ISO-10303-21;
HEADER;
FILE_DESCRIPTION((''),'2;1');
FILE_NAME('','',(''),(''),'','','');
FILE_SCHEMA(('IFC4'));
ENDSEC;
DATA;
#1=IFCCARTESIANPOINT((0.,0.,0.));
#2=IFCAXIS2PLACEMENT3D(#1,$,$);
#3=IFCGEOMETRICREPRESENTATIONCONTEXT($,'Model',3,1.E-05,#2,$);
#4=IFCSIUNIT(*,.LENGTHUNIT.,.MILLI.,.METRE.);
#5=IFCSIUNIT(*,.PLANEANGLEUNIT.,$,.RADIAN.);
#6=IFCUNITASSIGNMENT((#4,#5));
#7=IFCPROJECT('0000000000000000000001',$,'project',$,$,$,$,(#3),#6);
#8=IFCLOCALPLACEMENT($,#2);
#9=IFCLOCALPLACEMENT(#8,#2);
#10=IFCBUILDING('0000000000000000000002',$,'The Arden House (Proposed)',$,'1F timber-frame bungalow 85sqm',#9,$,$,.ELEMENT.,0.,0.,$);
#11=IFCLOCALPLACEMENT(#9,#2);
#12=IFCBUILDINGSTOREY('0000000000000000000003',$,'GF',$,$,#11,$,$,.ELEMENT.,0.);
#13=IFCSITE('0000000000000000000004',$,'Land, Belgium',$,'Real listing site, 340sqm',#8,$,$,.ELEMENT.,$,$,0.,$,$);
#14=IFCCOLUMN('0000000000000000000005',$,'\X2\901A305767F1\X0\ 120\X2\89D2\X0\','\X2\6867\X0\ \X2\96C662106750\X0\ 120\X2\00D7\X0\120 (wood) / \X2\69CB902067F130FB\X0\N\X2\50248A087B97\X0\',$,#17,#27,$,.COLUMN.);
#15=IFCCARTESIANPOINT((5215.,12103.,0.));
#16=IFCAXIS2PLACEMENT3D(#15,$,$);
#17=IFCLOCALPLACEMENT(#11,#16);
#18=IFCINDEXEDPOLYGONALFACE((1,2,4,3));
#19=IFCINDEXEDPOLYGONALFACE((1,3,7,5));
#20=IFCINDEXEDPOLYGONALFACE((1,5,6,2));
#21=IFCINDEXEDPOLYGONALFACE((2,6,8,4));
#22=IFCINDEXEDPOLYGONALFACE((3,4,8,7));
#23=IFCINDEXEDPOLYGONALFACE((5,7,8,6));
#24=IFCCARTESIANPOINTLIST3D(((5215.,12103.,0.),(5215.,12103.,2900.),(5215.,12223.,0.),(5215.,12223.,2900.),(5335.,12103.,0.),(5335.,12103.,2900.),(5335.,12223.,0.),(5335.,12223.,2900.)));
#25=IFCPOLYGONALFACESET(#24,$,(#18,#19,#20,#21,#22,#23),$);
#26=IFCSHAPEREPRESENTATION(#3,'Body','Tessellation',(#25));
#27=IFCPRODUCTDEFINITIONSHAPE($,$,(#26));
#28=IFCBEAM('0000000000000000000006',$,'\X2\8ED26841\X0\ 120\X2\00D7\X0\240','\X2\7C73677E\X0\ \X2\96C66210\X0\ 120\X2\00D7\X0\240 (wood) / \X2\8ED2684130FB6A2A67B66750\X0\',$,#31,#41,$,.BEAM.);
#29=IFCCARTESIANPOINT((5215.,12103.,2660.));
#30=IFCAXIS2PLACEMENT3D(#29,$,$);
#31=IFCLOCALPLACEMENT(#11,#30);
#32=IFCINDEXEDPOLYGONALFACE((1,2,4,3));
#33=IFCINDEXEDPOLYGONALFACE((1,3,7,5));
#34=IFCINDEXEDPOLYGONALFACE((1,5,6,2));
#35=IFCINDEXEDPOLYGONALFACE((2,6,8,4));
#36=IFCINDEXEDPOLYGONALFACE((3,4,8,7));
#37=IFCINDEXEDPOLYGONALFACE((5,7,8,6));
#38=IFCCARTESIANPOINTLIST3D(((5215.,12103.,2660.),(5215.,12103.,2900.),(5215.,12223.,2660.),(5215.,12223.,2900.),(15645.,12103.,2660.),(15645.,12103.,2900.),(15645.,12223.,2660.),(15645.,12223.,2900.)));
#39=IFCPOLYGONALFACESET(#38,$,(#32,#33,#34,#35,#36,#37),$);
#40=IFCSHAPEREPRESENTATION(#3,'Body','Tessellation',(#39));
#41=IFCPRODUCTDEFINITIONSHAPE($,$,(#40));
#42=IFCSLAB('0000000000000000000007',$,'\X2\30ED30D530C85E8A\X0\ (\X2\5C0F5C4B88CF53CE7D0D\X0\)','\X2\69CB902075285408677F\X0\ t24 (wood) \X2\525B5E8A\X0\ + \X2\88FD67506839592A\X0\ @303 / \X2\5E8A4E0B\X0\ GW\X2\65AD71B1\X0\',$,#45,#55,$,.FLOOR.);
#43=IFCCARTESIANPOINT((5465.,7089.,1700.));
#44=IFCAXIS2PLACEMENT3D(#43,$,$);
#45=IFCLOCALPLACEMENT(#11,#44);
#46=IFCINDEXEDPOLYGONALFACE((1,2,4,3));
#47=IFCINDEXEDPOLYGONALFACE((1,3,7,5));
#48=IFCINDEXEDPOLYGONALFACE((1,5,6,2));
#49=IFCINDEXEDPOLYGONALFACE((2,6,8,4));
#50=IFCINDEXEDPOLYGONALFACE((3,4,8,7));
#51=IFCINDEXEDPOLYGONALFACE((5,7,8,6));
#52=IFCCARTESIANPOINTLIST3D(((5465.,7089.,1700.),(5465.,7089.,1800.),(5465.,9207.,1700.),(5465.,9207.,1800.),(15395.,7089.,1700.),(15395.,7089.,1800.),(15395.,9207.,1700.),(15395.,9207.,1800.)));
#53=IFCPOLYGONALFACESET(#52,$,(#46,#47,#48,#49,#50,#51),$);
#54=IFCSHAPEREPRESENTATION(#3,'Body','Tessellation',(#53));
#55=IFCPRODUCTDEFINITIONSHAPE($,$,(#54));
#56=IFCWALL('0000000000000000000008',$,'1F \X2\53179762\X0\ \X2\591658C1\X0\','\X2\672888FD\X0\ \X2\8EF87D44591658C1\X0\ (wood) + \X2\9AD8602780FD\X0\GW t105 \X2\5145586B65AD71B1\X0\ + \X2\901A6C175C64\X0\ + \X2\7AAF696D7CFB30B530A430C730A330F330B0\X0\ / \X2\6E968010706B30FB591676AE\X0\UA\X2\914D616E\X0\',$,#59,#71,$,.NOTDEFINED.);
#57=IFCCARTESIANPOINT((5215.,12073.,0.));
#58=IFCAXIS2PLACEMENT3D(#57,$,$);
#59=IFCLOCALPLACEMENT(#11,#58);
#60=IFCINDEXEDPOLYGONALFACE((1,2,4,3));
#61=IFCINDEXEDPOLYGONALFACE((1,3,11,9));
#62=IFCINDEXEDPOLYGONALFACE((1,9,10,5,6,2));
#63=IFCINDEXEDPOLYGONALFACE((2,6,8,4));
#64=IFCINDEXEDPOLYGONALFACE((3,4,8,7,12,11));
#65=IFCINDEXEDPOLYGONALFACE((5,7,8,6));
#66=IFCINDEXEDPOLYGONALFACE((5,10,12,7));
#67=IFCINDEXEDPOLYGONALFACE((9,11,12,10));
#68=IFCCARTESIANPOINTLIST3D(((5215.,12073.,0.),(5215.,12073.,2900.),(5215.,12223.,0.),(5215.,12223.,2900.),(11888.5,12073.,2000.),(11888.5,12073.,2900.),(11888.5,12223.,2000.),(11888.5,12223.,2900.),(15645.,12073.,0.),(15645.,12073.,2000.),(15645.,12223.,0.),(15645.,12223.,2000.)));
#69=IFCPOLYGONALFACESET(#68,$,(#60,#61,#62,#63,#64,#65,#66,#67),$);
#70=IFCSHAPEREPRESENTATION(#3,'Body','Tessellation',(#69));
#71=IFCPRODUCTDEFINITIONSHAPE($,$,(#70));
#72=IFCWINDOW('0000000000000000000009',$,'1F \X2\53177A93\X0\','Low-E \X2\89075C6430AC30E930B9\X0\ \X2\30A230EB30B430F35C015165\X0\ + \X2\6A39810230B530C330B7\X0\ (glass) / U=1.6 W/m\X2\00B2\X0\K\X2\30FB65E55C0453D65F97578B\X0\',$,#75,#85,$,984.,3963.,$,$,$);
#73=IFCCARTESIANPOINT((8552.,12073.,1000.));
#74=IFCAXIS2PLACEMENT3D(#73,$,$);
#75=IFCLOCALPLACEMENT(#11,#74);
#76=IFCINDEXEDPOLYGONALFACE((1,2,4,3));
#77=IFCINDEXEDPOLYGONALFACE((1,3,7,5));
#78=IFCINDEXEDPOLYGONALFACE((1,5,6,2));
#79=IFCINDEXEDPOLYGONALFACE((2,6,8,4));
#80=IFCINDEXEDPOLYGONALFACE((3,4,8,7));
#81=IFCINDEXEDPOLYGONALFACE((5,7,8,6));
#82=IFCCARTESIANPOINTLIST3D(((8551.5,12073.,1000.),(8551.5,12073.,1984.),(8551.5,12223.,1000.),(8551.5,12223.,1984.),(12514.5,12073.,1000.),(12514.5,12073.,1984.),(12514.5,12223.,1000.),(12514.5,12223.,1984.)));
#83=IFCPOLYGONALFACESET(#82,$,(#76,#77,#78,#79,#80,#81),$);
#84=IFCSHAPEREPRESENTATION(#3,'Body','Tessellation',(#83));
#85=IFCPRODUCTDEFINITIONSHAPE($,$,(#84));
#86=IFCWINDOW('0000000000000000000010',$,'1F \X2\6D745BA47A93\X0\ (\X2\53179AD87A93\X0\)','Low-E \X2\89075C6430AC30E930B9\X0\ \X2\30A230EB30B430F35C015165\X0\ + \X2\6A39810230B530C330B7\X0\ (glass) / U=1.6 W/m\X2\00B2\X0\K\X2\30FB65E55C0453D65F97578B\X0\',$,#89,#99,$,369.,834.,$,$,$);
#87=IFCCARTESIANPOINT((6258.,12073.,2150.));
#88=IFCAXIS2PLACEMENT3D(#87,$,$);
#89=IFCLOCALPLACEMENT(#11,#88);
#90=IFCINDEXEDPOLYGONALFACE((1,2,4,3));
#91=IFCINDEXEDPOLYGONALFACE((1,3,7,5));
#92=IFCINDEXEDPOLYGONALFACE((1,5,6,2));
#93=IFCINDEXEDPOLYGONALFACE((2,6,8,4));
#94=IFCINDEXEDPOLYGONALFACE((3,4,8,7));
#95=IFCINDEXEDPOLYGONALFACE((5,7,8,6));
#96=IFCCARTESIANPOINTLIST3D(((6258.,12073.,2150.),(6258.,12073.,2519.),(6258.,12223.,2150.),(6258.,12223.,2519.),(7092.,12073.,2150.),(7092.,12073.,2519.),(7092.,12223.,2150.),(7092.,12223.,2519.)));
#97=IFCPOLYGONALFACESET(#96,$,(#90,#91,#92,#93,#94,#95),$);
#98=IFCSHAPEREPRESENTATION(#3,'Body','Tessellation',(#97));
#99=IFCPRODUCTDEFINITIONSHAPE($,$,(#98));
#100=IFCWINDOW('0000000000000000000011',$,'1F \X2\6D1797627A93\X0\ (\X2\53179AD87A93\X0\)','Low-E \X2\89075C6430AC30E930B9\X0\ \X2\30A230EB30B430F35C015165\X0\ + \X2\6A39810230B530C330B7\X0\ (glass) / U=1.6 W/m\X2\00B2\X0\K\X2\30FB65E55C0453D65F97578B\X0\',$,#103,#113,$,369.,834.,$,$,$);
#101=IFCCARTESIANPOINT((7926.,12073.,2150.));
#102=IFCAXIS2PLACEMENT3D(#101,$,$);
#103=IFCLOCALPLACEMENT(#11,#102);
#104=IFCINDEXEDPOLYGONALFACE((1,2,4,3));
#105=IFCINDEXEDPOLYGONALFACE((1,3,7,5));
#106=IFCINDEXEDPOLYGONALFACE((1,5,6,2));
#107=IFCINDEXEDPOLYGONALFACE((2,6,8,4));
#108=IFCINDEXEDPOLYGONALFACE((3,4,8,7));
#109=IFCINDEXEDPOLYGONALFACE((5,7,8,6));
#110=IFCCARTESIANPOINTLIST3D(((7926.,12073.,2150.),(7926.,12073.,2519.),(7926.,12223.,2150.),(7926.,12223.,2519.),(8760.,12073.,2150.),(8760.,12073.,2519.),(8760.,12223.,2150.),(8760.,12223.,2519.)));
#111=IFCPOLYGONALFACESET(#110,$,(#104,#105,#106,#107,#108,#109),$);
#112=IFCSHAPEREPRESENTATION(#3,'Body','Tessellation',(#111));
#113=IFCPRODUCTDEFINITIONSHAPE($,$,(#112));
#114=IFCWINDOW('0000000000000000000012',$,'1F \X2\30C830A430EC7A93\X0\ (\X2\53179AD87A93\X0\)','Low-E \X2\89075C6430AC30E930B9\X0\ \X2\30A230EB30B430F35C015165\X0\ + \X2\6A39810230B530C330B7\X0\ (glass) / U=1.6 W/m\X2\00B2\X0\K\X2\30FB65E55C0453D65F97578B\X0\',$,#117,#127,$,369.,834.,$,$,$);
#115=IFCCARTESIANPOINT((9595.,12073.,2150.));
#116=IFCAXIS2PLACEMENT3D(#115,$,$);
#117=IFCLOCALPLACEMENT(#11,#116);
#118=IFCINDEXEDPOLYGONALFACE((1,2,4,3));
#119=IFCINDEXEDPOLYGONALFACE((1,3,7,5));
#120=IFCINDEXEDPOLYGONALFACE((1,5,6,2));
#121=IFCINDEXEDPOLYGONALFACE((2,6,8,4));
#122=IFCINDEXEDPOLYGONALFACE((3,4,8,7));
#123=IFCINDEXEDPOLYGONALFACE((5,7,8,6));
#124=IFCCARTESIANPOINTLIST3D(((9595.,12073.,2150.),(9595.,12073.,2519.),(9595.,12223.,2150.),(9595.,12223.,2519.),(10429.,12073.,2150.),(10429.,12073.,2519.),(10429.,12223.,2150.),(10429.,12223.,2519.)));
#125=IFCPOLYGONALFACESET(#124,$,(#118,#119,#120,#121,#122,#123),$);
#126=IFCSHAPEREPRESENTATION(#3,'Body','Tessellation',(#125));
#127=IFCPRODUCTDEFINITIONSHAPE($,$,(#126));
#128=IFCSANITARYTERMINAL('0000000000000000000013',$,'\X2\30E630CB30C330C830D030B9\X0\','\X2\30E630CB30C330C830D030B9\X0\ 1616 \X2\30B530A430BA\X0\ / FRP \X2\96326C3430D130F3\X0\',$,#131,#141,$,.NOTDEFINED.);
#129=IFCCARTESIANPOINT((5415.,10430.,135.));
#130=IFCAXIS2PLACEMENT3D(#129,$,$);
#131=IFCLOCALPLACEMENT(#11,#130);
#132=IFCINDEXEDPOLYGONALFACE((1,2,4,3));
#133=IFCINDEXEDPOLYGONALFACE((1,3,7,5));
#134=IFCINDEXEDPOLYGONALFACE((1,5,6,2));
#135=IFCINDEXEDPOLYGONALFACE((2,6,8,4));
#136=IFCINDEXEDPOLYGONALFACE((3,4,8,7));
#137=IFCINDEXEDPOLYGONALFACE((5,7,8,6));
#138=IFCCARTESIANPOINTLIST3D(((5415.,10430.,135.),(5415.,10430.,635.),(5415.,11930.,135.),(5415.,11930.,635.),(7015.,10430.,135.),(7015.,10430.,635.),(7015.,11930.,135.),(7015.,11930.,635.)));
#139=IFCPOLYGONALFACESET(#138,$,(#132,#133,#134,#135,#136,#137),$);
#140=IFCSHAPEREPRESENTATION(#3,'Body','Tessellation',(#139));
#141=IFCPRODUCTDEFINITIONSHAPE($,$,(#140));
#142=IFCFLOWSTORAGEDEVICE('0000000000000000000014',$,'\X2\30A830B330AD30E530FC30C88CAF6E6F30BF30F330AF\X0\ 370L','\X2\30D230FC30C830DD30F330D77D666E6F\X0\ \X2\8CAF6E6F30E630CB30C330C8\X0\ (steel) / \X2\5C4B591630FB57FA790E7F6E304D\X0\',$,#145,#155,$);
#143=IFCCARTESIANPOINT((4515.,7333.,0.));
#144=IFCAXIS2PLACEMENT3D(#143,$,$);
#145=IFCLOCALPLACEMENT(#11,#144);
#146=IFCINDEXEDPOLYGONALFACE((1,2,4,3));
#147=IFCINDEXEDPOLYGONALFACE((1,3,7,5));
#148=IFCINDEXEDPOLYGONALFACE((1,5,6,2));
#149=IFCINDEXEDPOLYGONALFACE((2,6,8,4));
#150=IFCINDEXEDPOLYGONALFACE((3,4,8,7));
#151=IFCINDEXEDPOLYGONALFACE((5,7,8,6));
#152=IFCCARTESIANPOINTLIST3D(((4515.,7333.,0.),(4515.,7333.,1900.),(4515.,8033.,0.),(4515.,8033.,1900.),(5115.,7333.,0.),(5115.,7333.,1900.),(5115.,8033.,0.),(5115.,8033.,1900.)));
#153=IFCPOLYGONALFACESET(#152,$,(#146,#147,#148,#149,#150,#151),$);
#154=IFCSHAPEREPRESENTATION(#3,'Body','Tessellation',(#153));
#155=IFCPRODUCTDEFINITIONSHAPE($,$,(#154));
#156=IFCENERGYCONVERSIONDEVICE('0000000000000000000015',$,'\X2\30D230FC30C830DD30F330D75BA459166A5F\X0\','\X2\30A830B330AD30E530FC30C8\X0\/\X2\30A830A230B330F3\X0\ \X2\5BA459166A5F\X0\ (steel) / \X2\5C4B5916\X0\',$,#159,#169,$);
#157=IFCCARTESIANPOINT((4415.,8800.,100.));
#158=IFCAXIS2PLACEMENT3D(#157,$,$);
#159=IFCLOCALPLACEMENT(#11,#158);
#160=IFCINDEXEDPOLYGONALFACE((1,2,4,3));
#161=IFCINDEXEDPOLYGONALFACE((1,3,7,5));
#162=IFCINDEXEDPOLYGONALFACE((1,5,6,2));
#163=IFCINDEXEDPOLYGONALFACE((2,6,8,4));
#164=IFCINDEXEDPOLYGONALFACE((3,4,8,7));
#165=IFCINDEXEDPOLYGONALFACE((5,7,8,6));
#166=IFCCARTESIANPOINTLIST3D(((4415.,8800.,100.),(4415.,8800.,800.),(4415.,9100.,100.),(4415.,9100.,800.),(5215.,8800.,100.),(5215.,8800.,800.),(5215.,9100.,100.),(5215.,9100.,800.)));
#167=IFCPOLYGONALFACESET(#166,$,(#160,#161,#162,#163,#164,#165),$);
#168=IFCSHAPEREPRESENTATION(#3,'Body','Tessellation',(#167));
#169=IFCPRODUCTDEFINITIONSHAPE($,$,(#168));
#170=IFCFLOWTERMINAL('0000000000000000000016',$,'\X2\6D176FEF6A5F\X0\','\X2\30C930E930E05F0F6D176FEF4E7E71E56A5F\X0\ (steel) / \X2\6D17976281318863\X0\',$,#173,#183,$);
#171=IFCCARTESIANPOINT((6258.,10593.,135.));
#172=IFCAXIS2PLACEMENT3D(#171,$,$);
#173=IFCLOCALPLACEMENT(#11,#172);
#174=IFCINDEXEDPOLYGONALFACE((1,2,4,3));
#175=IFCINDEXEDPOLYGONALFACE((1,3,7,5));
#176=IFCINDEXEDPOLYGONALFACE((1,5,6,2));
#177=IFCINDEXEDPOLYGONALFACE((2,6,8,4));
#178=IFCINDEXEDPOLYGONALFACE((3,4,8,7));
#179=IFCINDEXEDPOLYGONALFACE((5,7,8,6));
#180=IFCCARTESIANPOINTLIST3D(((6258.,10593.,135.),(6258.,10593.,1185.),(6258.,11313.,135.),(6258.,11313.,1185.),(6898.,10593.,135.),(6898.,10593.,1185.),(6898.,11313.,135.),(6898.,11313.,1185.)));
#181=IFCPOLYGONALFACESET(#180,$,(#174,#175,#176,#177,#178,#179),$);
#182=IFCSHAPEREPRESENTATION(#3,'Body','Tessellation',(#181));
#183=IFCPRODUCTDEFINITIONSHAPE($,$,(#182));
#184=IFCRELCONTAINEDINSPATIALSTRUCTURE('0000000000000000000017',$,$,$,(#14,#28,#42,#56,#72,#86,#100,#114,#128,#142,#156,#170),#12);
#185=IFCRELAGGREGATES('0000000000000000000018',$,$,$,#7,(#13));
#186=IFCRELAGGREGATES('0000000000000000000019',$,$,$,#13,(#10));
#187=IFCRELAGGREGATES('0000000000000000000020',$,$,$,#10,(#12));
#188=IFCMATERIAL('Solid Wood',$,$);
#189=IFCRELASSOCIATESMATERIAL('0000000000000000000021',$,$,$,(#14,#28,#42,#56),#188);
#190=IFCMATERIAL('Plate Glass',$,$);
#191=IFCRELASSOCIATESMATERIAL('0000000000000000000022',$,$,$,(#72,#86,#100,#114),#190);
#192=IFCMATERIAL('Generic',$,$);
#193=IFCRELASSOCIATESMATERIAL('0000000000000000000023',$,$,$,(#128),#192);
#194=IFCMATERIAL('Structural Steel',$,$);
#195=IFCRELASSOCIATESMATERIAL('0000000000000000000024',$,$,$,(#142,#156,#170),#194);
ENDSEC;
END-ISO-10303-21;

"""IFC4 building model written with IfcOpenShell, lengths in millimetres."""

from ifc_helpers import new_model, si_unit, frame, frame_2d, origin, place, context, project, spatial, rectangle, extrude, material, element, fill, save


model = new_model("IFC4")

# Units and contexts
model_context = context("Model", 3, precision=1e-05, world=origin())
ifc_project = project(units=[si_unit("LENGTHUNIT", "METRE", prefix="MILLI"), si_unit("PLANEANGLEUNIT", "RADIAN")], contexts=[model_context])

# Site, building, storey
site_placement = place(None, origin())
site = spatial("IfcSite", under=ifc_project, at=site_placement, Name="Land, Belgium", ObjectType="Real listing site, 340sqm", CompositionType="ELEMENT", RefElevation=0.0)
building_placement = place(site_placement, origin())
building = spatial("IfcBuilding", under=site, at=building_placement, Name="The Arden House (Proposed)", ObjectType="1F timber-frame bungalow 85sqm", CompositionType="ELEMENT", ElevationOfRefHeight=0.0, ElevationOfTerrain=0.0)
storey_placement = place(building_placement, origin())
storey = spatial("IfcBuildingStorey", under=building, at=storey_placement, Name="GF", CompositionType="ELEMENT", Elevation=0.0)

# Column
ifc_material_1 = material(Name="Solid Wood")
column_1_placement = place(storey_placement, frame((5215.0, 12103.0, 0.0)))
element("IfcColumn", 1, at=column_1_placement, inside=storey, material=ifc_material_1, Name="通し柱 120角", Description="桧 集成材 120×120 (wood) / 構造柱・N値計算", PredefinedType="COLUMN", context=model_context, shape_type="SweptSolid", body=[
    extrude(rectangle(XDim=120.0, YDim=120.0, at=frame_2d((60.0, 60.0))), frame((5215.0, 12103.0, 0.0)), (0.0, 0.0, 1.0), 2900.0),
])

# Beam
beam_1_placement = place(storey_placement, frame((5215.0, 12103.0, 2660.0)))
element("IfcBeam", 2, at=beam_1_placement, inside=storey, material=ifc_material_1, Name="軒桁 120×240", Description="米松 集成 120×240 (wood) / 軒桁・横架材", PredefinedType="BEAM", context=model_context, shape_type="SweptSolid", body=[
    extrude(rectangle(XDim=10430.0, YDim=120.0, at=frame_2d((5215.0, 60.0))), frame((5215.0, 12103.0, 2660.0)), (0.0, 0.0, 1.0), 240.0),
])

# Slab
slab_placement = place(storey_placement, frame((5465.0, 7089.0, 1700.0)))
element("IfcSlab", 3, at=slab_placement, inside=storey, material=ifc_material_1, Name="ロフト床 (小屋裏収納)", Description="構造用合板 t24 (wood) 剛床 + 製材根太 @303 / 床下 GW断熱", PredefinedType="FLOOR", context=model_context, shape_type="SweptSolid", body=[
    extrude(rectangle(XDim=9930.0, YDim=2118.0, at=frame_2d((4965.0, 1059.0))), frame((5465.0, 7089.0, 1700.0)), (0.0, 0.0, 1.0), 100.0),
])

# Wall, openings, windows
wall_1_placement = place(storey_placement, frame((5215.0, 12073.0, 0.0)))
wall_1 = element("IfcWall", 4, at=wall_1_placement, inside=storey, material=ifc_material_1, Name="1F 北面 外壁", Description="木製 軸組外壁 (wood) + 高性能GW t105 充填断熱 + 通気層 + 窯業系サイディング / 準耐火・外皮UA配慮", PredefinedType="NOTDEFINED", context=model_context, shape_type="SweptSolid", body=[
    extrude(rectangle(XDim=10430.0, YDim=150.0, at=frame_2d((5215.0, 75.0))), frame((5215.0, 12073.0, 0.0)), (0.0, 0.0, 1.0), 2900.0),
])
opening_1_placement = place(storey_placement, frame((8552.0, 12073.0, 1000.0)))
opening_1 = element("IfcOpeningElement", 5, at=opening_1_placement, cuts=wall_1, PredefinedType="NOTDEFINED", context=model_context, shape_type="SweptSolid", body=[
    extrude(rectangle(XDim=3963.0, YDim=150.0, at=frame_2d((1981.0, 75.0))), frame((8552.0, 12073.0, 1000.0)), (0.0, 0.0, 1.0), 984.0),
])
opening_2_placement = place(storey_placement, frame((6258.0, 12073.0, 2150.0)))
opening_2 = element("IfcOpeningElement", 6, at=opening_2_placement, cuts=wall_1, PredefinedType="NOTDEFINED", context=model_context, shape_type="SweptSolid", body=[
    extrude(rectangle(XDim=834.0, YDim=150.0, at=frame_2d((417.0, 75.0))), frame((6258.0, 12073.0, 2150.0)), (0.0, 0.0, 1.0), 369.0),
])
opening_3_placement = place(storey_placement, frame((7926.0, 12073.0, 2150.0)))
opening_3 = element("IfcOpeningElement", 7, at=opening_3_placement, cuts=wall_1, PredefinedType="NOTDEFINED", context=model_context, shape_type="SweptSolid", body=[
    extrude(rectangle(XDim=834.0, YDim=150.0, at=frame_2d((417.0, 75.0))), frame((7926.0, 12073.0, 2150.0)), (0.0, 0.0, 1.0), 369.0),
])
opening_4_placement = place(storey_placement, frame((9595.0, 12073.0, 2150.0)))
opening_4 = element("IfcOpeningElement", 8, at=opening_4_placement, cuts=wall_1, PredefinedType="NOTDEFINED", context=model_context, shape_type="SweptSolid", body=[
    extrude(rectangle(XDim=834.0, YDim=150.0, at=frame_2d((417.0, 75.0))), frame((9595.0, 12073.0, 2150.0)), (0.0, 0.0, 1.0), 369.0),
])
ifc_material_2 = material(Name="Plate Glass")
window_1_placement = place(storey_placement, frame((8552.0, 12073.0, 1000.0)))
window_1 = element("IfcWindow", 9, at=window_1_placement, inside=storey, material=ifc_material_2, Name="1F 北窓", Description="Low-E 複層ガラス アルゴン封入 + 樹脂サッシ (glass) / U=1.6 W/m²K・日射取得型", OverallHeight=984.0, OverallWidth=3963.0, context=model_context, shape_type="SweptSolid", body=[
    extrude(rectangle(XDim=3963.0, YDim=150.0, at=frame_2d((1981.0, 75.0))), frame((8552.0, 12073.0, 1000.0)), (0.0, 0.0, 1.0), 984.0),
])
fill(opening_1, window_1)
window_2_placement = place(storey_placement, frame((6258.0, 12073.0, 2150.0)))
window_2 = element("IfcWindow", 10, at=window_2_placement, inside=storey, material=ifc_material_2, Name="1F 浴室窓 (北高窓)", Description="Low-E 複層ガラス アルゴン封入 + 樹脂サッシ (glass) / U=1.6 W/m²K・日射取得型", OverallHeight=369.0, OverallWidth=834.0, context=model_context, shape_type="SweptSolid", body=[
    extrude(rectangle(XDim=834.0, YDim=150.0, at=frame_2d((417.0, 75.0))), frame((6258.0, 12073.0, 2150.0)), (0.0, 0.0, 1.0), 369.0),
])
fill(opening_2, window_2)
window_3_placement = place(storey_placement, frame((7926.0, 12073.0, 2150.0)))
window_3 = element("IfcWindow", 11, at=window_3_placement, inside=storey, material=ifc_material_2, Name="1F 洗面窓 (北高窓)", Description="Low-E 複層ガラス アルゴン封入 + 樹脂サッシ (glass) / U=1.6 W/m²K・日射取得型", OverallHeight=369.0, OverallWidth=834.0, context=model_context, shape_type="SweptSolid", body=[
    extrude(rectangle(XDim=834.0, YDim=150.0, at=frame_2d((417.0, 75.0))), frame((7926.0, 12073.0, 2150.0)), (0.0, 0.0, 1.0), 369.0),
])
fill(opening_3, window_3)
window_4_placement = place(storey_placement, frame((9595.0, 12073.0, 2150.0)))
window_4 = element("IfcWindow", 12, at=window_4_placement, inside=storey, material=ifc_material_2, Name="1F トイレ窓 (北高窓)", Description="Low-E 複層ガラス アルゴン封入 + 樹脂サッシ (glass) / U=1.6 W/m²K・日射取得型", OverallHeight=369.0, OverallWidth=834.0, context=model_context, shape_type="SweptSolid", body=[
    extrude(rectangle(XDim=834.0, YDim=150.0, at=frame_2d((417.0, 75.0))), frame((9595.0, 12073.0, 2150.0)), (0.0, 0.0, 1.0), 369.0),
])
fill(opening_4, window_4)

# Sanitary terminal
ifc_material_3 = material(Name="Generic")
sanitary_terminal_placement = place(storey_placement, frame((5415.0, 10430.0, 135.0)))
element("IfcSanitaryTerminal", 13, at=sanitary_terminal_placement, inside=storey, material=ifc_material_3, Name="ユニットバス", Description="ユニットバス 1616 サイズ / FRP 防水パン", PredefinedType="NOTDEFINED", context=model_context, shape_type="SweptSolid", body=[
    extrude(rectangle(XDim=1600.0, YDim=1500.0, at=frame_2d((800.0, 750.0))), frame((5415.0, 10430.0, 135.0)), (0.0, 0.0, 1.0), 500.0),
])

# Flow storage device
ifc_material_4 = material(Name="Structural Steel")
flow_storage_device_placement = place(storey_placement, frame((4515.0, 7333.0, 0.0)))
element("IfcFlowStorageDevice", 14, at=flow_storage_device_placement, inside=storey, material=ifc_material_4, Name="エコキュート貯湯タンク 370L", Description="ヒートポンプ給湯 貯湯ユニット (steel) / 屋外・基礎置き", context=model_context, shape_type="SweptSolid", body=[
    extrude(rectangle(XDim=600.0, YDim=700.0, at=frame_2d((300.0, 350.0))), frame((4515.0, 7333.0, 0.0)), (0.0, 0.0, 1.0), 1900.0),
])

# Energy conversion device
energy_conversion_device_placement = place(storey_placement, frame((4415.0, 8800.0, 100.0)))
element("IfcEnergyConversionDevice", 15, at=energy_conversion_device_placement, inside=storey, material=ifc_material_4, Name="ヒートポンプ室外機", Description="エコキュート/エアコン 室外機 (steel) / 屋外", context=model_context, shape_type="SweptSolid", body=[
    extrude(rectangle(XDim=800.0, YDim=300.0, at=frame_2d((400.0, 150.0))), frame((4415.0, 8800.0, 100.0)), (0.0, 0.0, 1.0), 700.0),
])

# Flow terminal
flow_terminal_placement = place(storey_placement, frame((6258.0, 10593.0, 135.0)))
element("IfcFlowTerminal", 16, at=flow_terminal_placement, inside=storey, material=ifc_material_4, Name="洗濯機", Description="ドラム式洗濯乾燥機 (steel) / 洗面脱衣", context=model_context, shape_type="SweptSolid", body=[
    extrude(rectangle(XDim=640.0, YDim=720.0, at=frame_2d((320.0, 360.0))), frame((6258.0, 10593.0, 135.0)), (0.0, 0.0, 1.0), 1050.0),
])

save(model, "model.ifc")
